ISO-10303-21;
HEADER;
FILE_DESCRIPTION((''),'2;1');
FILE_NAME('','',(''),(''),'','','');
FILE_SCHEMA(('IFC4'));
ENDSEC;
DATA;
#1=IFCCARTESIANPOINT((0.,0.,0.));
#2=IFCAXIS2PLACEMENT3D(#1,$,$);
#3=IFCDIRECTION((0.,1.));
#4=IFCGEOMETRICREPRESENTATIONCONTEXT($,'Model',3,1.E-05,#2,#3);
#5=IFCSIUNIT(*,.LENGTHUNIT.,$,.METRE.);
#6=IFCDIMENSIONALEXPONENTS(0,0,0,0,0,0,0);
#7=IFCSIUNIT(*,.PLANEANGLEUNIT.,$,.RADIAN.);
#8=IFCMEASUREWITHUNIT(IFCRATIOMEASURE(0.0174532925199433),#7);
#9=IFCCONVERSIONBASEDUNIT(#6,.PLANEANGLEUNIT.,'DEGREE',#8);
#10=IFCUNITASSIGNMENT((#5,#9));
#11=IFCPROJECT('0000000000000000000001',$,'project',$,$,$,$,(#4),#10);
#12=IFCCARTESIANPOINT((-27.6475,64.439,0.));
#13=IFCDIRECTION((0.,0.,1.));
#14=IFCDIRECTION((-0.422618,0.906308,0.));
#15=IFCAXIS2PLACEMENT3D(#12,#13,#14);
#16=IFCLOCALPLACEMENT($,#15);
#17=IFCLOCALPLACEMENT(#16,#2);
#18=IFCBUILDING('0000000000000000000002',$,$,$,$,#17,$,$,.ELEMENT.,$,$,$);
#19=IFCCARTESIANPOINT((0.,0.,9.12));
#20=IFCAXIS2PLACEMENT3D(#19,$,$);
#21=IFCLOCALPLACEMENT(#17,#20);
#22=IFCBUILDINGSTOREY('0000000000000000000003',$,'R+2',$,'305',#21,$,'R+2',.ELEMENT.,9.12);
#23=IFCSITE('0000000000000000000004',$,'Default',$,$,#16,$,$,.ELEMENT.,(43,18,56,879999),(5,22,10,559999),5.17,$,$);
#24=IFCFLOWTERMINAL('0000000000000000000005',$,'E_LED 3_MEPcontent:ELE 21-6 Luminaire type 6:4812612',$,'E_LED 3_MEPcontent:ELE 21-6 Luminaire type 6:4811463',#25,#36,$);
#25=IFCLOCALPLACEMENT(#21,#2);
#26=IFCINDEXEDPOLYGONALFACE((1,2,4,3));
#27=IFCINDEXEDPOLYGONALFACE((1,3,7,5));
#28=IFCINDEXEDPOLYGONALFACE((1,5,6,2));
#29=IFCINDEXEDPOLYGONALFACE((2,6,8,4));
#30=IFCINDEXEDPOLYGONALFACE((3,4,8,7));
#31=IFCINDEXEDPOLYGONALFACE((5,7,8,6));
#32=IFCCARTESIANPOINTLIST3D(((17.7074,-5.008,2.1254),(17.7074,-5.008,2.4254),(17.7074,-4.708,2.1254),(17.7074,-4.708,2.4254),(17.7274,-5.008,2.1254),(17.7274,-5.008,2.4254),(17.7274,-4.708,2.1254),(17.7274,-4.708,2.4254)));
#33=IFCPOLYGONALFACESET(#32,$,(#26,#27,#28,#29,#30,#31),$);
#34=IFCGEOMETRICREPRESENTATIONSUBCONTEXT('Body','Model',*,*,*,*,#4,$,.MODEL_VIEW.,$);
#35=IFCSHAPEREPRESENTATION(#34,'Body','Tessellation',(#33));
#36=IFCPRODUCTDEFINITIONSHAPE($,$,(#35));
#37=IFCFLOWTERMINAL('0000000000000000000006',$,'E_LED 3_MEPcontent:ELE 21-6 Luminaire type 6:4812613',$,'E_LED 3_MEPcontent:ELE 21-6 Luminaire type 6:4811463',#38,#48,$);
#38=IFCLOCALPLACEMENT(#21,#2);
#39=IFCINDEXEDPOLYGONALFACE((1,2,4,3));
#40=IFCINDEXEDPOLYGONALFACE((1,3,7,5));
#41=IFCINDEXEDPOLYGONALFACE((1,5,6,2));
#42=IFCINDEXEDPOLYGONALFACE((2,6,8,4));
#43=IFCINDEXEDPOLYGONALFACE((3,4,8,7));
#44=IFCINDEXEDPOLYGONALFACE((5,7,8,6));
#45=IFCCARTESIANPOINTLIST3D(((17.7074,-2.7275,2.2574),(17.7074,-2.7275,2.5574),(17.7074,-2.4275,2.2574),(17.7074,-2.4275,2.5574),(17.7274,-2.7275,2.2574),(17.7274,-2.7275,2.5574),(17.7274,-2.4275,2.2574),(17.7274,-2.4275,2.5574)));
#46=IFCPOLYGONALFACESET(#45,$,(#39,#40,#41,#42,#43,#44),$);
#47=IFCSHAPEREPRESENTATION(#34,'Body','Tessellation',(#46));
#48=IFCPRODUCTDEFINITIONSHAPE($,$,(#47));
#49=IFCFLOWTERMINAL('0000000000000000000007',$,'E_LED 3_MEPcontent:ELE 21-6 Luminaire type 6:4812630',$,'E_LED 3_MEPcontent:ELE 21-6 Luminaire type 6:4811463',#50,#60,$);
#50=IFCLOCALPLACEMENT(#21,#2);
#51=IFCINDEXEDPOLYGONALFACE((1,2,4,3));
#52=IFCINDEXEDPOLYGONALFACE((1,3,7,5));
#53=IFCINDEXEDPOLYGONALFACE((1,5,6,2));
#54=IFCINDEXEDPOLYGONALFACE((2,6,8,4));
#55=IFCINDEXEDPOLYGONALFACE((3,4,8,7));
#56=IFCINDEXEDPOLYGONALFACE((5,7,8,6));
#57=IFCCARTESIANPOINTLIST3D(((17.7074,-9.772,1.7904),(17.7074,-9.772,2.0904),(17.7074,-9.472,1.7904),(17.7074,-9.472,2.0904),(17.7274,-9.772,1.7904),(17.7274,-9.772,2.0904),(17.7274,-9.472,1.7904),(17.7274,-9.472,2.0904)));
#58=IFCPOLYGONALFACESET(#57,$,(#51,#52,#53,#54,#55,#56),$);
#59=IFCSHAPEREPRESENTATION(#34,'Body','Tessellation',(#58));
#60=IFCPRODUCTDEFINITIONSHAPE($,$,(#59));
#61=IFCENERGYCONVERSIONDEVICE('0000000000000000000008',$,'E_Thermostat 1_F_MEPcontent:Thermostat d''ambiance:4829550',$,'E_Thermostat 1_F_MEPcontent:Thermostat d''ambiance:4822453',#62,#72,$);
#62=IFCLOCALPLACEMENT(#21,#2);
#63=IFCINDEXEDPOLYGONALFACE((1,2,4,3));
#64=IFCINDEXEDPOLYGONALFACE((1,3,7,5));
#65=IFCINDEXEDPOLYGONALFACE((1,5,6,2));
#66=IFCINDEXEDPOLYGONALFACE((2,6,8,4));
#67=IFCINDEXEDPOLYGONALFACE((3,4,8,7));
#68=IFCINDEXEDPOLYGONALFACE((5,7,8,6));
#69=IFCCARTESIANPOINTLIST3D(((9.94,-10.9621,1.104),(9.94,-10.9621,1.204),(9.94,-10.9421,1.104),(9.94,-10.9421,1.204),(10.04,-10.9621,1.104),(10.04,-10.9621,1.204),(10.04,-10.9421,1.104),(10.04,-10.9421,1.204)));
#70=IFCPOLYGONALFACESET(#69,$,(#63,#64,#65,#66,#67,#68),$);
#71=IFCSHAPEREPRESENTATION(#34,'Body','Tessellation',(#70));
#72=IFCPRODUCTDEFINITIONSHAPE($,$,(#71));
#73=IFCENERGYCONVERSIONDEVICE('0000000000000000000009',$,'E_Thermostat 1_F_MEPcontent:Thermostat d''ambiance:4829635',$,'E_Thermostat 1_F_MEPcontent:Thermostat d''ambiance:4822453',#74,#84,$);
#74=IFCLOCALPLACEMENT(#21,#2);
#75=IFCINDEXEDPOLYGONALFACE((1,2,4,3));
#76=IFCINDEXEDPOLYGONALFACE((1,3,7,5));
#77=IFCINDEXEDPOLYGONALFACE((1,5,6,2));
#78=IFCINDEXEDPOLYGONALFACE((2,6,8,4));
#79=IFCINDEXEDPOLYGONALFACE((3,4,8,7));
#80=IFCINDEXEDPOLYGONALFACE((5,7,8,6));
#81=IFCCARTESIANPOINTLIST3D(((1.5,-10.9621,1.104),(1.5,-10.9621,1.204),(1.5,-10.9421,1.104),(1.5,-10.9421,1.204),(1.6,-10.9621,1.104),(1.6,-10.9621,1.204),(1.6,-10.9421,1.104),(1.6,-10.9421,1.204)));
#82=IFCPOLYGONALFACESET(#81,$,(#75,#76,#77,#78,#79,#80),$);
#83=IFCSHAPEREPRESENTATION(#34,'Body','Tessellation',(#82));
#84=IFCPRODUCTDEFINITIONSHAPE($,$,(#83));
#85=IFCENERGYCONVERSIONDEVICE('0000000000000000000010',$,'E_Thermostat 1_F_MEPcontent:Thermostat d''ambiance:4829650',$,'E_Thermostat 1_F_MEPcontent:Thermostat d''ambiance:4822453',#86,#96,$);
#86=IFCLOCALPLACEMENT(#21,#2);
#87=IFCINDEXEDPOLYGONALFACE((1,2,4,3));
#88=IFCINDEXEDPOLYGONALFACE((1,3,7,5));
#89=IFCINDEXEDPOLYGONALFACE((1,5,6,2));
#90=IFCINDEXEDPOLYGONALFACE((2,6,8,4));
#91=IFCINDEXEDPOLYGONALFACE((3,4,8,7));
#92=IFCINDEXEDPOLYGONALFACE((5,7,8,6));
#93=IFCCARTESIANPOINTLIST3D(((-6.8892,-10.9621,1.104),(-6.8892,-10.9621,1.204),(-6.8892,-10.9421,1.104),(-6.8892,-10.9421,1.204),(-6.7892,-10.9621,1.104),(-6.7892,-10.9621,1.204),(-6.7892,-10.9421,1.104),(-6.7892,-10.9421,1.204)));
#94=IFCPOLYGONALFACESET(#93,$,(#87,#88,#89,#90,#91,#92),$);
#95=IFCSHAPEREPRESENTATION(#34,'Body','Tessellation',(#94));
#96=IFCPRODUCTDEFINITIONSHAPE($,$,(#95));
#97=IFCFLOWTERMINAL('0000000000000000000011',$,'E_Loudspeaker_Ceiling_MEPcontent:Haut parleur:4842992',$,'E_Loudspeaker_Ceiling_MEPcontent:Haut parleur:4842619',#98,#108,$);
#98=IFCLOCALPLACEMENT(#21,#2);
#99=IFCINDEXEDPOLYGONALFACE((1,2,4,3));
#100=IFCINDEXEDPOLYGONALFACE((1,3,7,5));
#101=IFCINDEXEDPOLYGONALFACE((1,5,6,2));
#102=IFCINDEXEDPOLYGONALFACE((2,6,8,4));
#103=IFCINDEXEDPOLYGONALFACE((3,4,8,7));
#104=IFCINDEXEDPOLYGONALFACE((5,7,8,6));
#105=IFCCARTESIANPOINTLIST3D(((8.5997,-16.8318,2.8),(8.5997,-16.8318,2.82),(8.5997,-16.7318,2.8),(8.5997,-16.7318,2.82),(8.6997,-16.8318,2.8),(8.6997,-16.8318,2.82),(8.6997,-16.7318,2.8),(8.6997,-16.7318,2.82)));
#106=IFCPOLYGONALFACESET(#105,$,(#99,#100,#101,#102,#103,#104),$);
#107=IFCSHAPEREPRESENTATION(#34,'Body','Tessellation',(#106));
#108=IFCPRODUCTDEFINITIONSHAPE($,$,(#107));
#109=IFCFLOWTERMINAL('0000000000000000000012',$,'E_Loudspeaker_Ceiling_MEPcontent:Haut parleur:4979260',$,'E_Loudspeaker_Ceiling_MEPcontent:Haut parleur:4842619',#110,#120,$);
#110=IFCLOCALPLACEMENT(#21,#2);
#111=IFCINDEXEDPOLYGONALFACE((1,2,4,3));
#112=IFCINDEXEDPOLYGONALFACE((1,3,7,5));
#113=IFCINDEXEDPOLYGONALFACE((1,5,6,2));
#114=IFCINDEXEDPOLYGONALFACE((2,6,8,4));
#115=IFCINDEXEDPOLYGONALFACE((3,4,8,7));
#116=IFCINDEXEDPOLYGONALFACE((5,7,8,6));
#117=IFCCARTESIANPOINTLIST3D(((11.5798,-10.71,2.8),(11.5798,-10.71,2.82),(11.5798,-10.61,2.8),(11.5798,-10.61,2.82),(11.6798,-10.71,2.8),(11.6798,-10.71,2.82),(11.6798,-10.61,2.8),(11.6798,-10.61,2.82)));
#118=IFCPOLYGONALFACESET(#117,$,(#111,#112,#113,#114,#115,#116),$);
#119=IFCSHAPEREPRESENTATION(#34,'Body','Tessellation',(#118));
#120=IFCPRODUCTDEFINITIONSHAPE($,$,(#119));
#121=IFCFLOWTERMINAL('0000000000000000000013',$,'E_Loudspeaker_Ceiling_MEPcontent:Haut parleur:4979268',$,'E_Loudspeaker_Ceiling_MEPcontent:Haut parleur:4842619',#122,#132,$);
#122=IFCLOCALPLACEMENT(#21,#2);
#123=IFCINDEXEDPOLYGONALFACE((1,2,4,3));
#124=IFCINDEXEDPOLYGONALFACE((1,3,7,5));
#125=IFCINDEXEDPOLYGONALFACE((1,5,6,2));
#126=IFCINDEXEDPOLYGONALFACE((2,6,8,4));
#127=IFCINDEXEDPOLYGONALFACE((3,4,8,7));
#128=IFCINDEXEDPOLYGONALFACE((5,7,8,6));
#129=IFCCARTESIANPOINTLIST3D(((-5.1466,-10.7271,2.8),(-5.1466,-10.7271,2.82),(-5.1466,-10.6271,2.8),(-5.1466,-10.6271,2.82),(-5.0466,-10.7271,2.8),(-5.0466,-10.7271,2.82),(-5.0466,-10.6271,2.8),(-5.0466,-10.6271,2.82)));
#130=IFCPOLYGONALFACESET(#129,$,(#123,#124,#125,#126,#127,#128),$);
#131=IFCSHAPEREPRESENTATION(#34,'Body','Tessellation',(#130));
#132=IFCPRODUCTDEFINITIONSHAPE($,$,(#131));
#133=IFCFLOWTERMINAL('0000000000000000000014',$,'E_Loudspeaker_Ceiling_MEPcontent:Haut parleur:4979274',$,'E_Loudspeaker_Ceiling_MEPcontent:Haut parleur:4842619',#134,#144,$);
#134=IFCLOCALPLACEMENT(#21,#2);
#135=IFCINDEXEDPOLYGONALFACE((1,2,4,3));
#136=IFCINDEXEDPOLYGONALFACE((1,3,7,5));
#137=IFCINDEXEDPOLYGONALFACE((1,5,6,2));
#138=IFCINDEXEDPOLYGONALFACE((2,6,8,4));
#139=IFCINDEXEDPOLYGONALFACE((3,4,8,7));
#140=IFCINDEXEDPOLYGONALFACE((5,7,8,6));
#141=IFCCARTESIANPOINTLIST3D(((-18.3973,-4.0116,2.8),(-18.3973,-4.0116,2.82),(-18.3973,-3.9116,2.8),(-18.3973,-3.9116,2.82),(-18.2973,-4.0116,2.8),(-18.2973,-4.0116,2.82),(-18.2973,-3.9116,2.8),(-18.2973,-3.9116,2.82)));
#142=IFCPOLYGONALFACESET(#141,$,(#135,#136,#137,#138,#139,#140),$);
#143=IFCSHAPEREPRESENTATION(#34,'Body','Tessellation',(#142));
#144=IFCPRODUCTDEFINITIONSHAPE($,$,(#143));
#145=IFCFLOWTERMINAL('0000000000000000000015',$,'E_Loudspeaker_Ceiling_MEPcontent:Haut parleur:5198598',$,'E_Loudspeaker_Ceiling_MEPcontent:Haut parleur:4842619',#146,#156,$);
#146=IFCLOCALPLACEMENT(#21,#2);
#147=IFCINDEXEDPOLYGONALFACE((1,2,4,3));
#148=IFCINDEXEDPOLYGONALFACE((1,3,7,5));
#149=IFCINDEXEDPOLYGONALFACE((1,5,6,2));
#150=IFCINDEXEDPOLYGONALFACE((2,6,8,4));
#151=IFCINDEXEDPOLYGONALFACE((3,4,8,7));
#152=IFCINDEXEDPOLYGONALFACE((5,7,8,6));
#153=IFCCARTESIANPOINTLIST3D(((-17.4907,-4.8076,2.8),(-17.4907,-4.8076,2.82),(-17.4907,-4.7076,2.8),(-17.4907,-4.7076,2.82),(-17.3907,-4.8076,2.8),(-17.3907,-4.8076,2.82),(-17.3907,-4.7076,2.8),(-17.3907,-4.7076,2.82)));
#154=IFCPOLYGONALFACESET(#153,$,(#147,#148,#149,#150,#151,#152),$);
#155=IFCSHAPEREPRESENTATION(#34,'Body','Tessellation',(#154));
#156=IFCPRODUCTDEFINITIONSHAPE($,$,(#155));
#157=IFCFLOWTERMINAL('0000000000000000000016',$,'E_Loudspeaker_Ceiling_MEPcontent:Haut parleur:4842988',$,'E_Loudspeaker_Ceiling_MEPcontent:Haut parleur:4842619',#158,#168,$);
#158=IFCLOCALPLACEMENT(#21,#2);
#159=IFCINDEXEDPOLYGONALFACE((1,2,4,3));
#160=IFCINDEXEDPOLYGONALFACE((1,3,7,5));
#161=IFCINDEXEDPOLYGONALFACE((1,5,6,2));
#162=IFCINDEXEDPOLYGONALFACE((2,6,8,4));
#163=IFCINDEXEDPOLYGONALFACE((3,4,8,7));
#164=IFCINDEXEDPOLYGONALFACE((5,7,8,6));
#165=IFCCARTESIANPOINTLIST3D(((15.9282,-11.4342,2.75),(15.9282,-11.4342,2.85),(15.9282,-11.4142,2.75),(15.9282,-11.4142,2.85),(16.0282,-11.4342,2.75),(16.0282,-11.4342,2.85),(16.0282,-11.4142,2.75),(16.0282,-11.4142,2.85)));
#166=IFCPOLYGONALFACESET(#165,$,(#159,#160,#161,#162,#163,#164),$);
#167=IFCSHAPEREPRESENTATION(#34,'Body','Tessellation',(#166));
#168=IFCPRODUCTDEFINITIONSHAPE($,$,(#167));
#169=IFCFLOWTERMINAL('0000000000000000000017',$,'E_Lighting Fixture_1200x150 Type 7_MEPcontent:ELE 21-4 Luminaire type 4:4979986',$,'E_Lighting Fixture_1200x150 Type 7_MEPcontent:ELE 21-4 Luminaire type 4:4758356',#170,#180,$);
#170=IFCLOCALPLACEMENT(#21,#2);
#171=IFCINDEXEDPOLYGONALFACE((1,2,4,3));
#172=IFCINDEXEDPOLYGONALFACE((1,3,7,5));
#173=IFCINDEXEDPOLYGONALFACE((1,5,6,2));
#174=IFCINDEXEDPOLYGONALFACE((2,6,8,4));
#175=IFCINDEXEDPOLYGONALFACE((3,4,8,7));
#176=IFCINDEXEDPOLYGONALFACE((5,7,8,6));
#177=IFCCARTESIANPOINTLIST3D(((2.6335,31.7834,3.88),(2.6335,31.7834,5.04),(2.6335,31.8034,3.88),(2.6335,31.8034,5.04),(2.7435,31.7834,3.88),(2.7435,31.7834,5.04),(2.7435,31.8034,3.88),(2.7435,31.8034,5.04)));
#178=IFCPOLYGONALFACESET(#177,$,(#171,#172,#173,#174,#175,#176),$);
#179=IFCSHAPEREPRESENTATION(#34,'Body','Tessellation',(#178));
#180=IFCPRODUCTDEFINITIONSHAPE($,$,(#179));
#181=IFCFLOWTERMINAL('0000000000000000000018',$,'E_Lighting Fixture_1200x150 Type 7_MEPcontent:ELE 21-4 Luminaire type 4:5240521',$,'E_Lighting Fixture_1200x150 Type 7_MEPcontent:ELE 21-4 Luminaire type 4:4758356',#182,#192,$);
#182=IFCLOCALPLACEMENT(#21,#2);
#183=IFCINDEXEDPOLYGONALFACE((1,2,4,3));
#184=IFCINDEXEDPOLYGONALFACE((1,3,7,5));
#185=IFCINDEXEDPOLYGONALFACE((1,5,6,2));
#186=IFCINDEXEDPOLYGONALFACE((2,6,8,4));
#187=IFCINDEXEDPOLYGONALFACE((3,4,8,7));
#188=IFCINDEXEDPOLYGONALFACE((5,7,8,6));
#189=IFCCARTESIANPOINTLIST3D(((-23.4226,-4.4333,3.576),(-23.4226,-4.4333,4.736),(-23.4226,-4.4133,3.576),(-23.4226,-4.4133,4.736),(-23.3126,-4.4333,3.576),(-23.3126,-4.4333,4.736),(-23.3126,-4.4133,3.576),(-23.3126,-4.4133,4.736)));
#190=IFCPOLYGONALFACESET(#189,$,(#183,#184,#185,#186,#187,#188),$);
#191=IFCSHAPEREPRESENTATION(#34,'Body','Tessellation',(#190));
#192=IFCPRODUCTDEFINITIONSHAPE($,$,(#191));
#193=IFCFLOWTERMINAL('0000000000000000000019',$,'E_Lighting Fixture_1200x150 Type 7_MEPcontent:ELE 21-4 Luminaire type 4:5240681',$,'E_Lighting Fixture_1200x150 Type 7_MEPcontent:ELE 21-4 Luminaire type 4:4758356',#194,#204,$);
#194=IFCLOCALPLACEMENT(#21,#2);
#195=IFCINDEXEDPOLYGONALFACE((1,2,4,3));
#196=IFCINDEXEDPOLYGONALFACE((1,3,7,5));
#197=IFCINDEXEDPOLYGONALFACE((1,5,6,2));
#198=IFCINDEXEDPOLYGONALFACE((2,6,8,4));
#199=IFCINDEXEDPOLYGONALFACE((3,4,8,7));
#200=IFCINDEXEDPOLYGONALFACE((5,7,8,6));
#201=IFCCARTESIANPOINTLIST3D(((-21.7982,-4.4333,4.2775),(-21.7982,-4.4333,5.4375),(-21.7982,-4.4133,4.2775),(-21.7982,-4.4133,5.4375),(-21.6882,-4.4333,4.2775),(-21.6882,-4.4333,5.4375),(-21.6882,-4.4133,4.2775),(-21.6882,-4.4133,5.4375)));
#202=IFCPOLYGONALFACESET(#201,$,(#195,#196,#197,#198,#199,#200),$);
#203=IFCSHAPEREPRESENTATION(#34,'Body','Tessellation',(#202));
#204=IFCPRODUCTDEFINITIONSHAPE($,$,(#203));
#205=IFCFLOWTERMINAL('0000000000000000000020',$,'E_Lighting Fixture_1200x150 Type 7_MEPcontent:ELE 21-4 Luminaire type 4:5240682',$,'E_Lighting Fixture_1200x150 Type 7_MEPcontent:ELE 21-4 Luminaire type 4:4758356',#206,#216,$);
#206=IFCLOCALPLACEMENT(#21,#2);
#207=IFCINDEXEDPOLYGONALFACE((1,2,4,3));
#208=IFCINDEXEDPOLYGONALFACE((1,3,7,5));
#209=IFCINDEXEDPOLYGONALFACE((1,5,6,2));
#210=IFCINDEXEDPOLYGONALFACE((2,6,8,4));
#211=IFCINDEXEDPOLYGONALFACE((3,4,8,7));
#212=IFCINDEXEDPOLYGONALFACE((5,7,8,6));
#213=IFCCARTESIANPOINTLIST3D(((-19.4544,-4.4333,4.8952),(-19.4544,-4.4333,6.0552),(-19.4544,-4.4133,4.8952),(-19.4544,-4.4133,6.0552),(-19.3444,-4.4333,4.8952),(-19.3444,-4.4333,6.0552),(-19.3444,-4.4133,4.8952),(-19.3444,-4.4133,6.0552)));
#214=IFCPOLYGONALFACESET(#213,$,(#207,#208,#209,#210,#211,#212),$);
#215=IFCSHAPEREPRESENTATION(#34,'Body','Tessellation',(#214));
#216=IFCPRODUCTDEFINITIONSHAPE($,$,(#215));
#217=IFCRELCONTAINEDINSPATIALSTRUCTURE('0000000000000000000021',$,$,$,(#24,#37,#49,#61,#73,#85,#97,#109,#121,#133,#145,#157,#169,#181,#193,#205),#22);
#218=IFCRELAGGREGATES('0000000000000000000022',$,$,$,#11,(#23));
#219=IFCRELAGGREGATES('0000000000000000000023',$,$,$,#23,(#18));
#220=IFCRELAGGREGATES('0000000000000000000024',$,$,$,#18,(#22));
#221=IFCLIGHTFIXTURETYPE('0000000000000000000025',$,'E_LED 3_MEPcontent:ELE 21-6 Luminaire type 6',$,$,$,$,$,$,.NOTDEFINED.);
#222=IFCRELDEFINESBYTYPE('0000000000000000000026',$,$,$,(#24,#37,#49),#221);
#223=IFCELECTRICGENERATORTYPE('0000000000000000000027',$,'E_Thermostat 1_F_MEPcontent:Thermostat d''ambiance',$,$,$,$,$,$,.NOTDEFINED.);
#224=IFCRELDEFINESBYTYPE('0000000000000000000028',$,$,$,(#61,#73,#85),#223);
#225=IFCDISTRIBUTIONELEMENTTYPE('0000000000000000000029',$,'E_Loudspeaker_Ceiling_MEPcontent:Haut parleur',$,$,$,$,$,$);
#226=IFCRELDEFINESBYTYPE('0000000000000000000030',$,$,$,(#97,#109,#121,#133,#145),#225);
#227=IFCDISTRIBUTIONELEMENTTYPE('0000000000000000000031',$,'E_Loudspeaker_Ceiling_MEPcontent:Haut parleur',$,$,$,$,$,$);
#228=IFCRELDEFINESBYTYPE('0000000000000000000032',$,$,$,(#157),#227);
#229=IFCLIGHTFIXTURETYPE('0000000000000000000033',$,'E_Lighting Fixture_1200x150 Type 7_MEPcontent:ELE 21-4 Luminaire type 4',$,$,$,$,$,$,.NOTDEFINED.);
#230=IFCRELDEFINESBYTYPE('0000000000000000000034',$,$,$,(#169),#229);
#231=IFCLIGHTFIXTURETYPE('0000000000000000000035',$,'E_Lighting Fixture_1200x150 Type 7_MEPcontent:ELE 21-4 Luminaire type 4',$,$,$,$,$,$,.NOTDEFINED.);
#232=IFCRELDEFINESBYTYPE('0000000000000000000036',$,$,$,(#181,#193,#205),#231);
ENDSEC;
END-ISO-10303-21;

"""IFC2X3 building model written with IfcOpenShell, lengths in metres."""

from ifc_helpers import new_model, entity, si_unit, converted_unit, direction, frame, frame_2d, origin, origin_2d_with_axis, place, context, subcontext, project, spatial, rectangle, extrude, source, transform, mapped, type_object, type_shapes, element, save


model = new_model("IFC2X3")

# Units and contexts
model_context = context("Model", 3, precision=1e-05, world=origin(), true_north=direction((0.0, 1.0)))
body_context = subcontext(model_context, "Body", "Model", "MODEL_VIEW")
ifc_project = project(units=[si_unit("LENGTHUNIT", "METRE"), converted_unit("PLANEANGLEUNIT", "DEGREE", entity("IfcRatioMeasure", 0.0174532925199433), si_unit("PLANEANGLEUNIT", "RADIAN"), dimensions=[0, 0, 0, 0, 0, 0, 0])], contexts=[model_context])

# Site, building, storey
site_placement = place(None, frame((-27.6475, 64.439, 0.0), z_axis=(0.0, 0.0, 1.0), x_axis=(-0.422618, 0.906308, 0.0)))
site = spatial("IfcSite", under=ifc_project, at=site_placement, Name="Default", CompositionType="ELEMENT", RefLatitude=(43, 18, 56, 879999), RefLongitude=(5, 22, 10, 559999), RefElevation=5.17)
building_placement = place(site_placement, origin())
building = spatial("IfcBuilding", under=site, at=building_placement, CompositionType="ELEMENT")
storey_placement = place(building_placement, frame((0.0, 0.0, 9.12)))
storey = spatial("IfcBuildingStorey", under=building, at=storey_placement, Name="R+2", ObjectType="305", LongName="R+2", CompositionType="ELEMENT", Elevation=9.12)

# Flow terminals
light_fixture_type_1 = type_object("IfcLightFixtureType", Name="E_LED 3_MEPcontent:ELE 21-6 Luminaire type 6", PredefinedType="NOTDEFINED")
shared_shape_1 = source(origin(), body_context, "Body", "SweptSolid", [
    extrude(rectangle(XDim=0.02, YDim=0.3, at=origin_2d_with_axis()), frame((0.0, 0.01, -0.15), z_axis=(0.0, 0.0, 1.0), x_axis=(0.0, -1.0, 0.0)), (0.0, 0.0, 1.0), 0.3),
])
type_shapes(light_fixture_type_1, [shared_shape_1])
for number, where, z_axis, x_axis, name in (
    (1, (17.7074, -4.858, 2.2754), (0.0, 0.0, 1.0), (0.0, -1.0, 0.0), "E_LED 3_MEPcontent:ELE 21-6 Luminaire type 6:4812612"),
    (2, (17.7074, -2.5775, 2.4074), (0.0, 0.0, 1.0), (0.0, -1.0, 0.0), "E_LED 3_MEPcontent:ELE 21-6 Luminaire type 6:4812613"),
    (3, (17.7074, -9.622, 1.9404), (0.0, 0.0, 1.0), (0.0, -1.0, 0.0), "E_LED 3_MEPcontent:ELE 21-6 Luminaire type 6:4812630"),
):
    element("IfcFlowTerminal", number, at=place(storey_placement, frame(where, z_axis=z_axis, x_axis=x_axis)), inside=storey, type_object=light_fixture_type_1, Name=name, ObjectType="E_LED 3_MEPcontent:ELE 21-6 Luminaire type 6:4811463", context=body_context, shape_type="MappedRepresentation", body=[
        mapped(shared_shape_1, transform((0.0, 0.0, 0.0), scale=1.0)),
    ])

# Energy conversion devices
electric_generator_type = type_object("IfcElectricGeneratorType", Name="E_Thermostat 1_F_MEPcontent:Thermostat d'ambiance", PredefinedType="NOTDEFINED")
shared_shape_2 = source(origin(), body_context, "Body", "SweptSolid", [
    extrude(rectangle(XDim=0.1, YDim=0.1, at=origin_2d_with_axis()), frame((0.0, 0.0, 0.0), z_axis=(0.0, 0.0, 1.0), x_axis=(0.0, 1.0, 0.0)), (0.0, 0.0, 1.0), 0.02),
])
type_shapes(electric_generator_type, [shared_shape_2])
for number, where, z_axis, x_axis, name in (
    (4, (9.99, -10.9421, 1.154), (0.0, -1.0, 0.0), (1.0, 0.0, 0.0), "E_Thermostat 1_F_MEPcontent:Thermostat d'ambiance:4829550"),
    (5, (1.55, -10.9421, 1.154), (0.0, -1.0, 0.0), (1.0, 0.0, 0.0), "E_Thermostat 1_F_MEPcontent:Thermostat d'ambiance:4829635"),
    (6, (-6.8392, -10.9421, 1.154), (0.0, -1.0, 0.0), (1.0, 0.0, 0.0), "E_Thermostat 1_F_MEPcontent:Thermostat d'ambiance:4829650"),
):
    element("IfcEnergyConversionDevice", number, at=place(storey_placement, frame(where, z_axis=z_axis, x_axis=x_axis)), inside=storey, type_object=electric_generator_type, Name=name, ObjectType="E_Thermostat 1_F_MEPcontent:Thermostat d'ambiance:4822453", context=body_context, shape_type="MappedRepresentation", body=[
        mapped(shared_shape_2, transform((0.0, 0.0, 0.0), scale=1.0)),
    ])

# Flow terminals
distribution_element_type_1 = type_object("IfcDistributionElementType", Name="E_Loudspeaker_Ceiling_MEPcontent:Haut parleur")
shared_shape_3 = source(origin(), body_context, "Body", "SweptSolid", [
    extrude(rectangle(XDim=0.1, YDim=0.1, at=origin_2d_with_axis()), frame((0.0, 0.0, 0.0), z_axis=(0.0, 0.0, 1.0), x_axis=(0.0, -1.0, 0.0)), (0.0, 0.0, 1.0), 0.02),
])
type_shapes(distribution_element_type_1, [shared_shape_3])
flow_terminal_1_placement = place(storey_placement, frame((8.6497, -16.7818, 2.8), z_axis=(0.0, 0.0, 1.0), x_axis=(0.0, 1.0, 0.0)))
element("IfcFlowTerminal", 7, at=flow_terminal_1_placement, inside=storey, type_object=distribution_element_type_1, Name="E_Loudspeaker_Ceiling_MEPcontent:Haut parleur:4842992", ObjectType="E_Loudspeaker_Ceiling_MEPcontent:Haut parleur:4842619", context=body_context, shape_type="MappedRepresentation", body=[
    mapped(shared_shape_3, transform((0.0, 0.0, 0.0), scale=1.0)),
])
for number, where, name in (
    (8, (11.6298, -10.66, 2.8), "E_Loudspeaker_Ceiling_MEPcontent:Haut parleur:4979260"),
    (9, (-5.0966, -10.6771, 2.8), "E_Loudspeaker_Ceiling_MEPcontent:Haut parleur:4979268"),
    (10, (-18.3473, -3.9616, 2.8), "E_Loudspeaker_Ceiling_MEPcontent:Haut parleur:4979274"),
):
    element("IfcFlowTerminal", number, at=place(storey_placement, frame(where)), inside=storey, type_object=distribution_element_type_1, Name=name, ObjectType="E_Loudspeaker_Ceiling_MEPcontent:Haut parleur:4842619", context=body_context, shape_type="MappedRepresentation", body=[
        mapped(shared_shape_3, transform((0.0, 0.0, 0.0), scale=1.0)),
    ])
flow_terminal_2_placement = place(storey_placement, frame((-17.4407, -4.7576, 2.8), z_axis=(0.0, 0.0, 1.0), x_axis=(0.0, -1.0, 0.0)))
element("IfcFlowTerminal", 11, at=flow_terminal_2_placement, inside=storey, type_object=distribution_element_type_1, Name="E_Loudspeaker_Ceiling_MEPcontent:Haut parleur:5198598", ObjectType="E_Loudspeaker_Ceiling_MEPcontent:Haut parleur:4842619", context=body_context, shape_type="MappedRepresentation", body=[
    mapped(shared_shape_3, transform((0.0, 0.0, 0.0), scale=1.0)),
])
distribution_element_type_2 = type_object("IfcDistributionElementType", Name="E_Loudspeaker_Ceiling_MEPcontent:Haut parleur")
shared_shape_4 = source(origin(), body_context, "Body", "SweptSolid", [
    extrude(rectangle(XDim=0.02, YDim=0.1, at=frame_2d((0.0, 0.0), x_axis=(1.0, 0.0))), frame((0.0, 0.01, -0.05), z_axis=(0.0, 0.0, 1.0), x_axis=(0.0, -1.0, 0.0)), (0.0, 0.0, 1.0), 0.1),
])
type_shapes(distribution_element_type_2, [shared_shape_4])
flow_terminal_3_placement = place(storey_placement, frame((15.9782, -11.4142, 2.8), z_axis=(0.0, 0.0, 1.0), x_axis=(-1.0, 0.0, 0.0)))
element("IfcFlowTerminal", 12, at=flow_terminal_3_placement, inside=storey, type_object=distribution_element_type_2, Name="E_Loudspeaker_Ceiling_MEPcontent:Haut parleur:4842988", ObjectType="E_Loudspeaker_Ceiling_MEPcontent:Haut parleur:4842619", context=body_context, shape_type="MappedRepresentation", body=[
    mapped(shared_shape_4, transform((0.0, 0.0, 0.0), scale=1.0)),
])
light_fixture_type_2 = type_object("IfcLightFixtureType", Name="E_Lighting Fixture_1200x150 Type 7_MEPcontent:ELE 21-4 Luminaire type 4", PredefinedType="NOTDEFINED")
shared_shape_5 = source(origin(), body_context, "Body", "SweptSolid", [
    extrude(rectangle(XDim=0.02, YDim=0.11, at=frame_2d((0.0, 0.0), x_axis=(1.0, 0.0))), frame((0.01, 0.0, -0.58), z_axis=(0.0, 0.0, 1.0), x_axis=(-1.0, 0.0, 0.0)), (0.0, 0.0, 1.0), 1.16),
])
type_shapes(light_fixture_type_2, [shared_shape_5])
flow_terminal_4_placement = place(storey_placement, frame((2.6885, 31.8034, 4.46), z_axis=(0.0, 0.0, 1.0), x_axis=(0.0, -1.0, 0.0)))
element("IfcFlowTerminal", 13, at=flow_terminal_4_placement, inside=storey, type_object=light_fixture_type_2, Name="E_Lighting Fixture_1200x150 Type 7_MEPcontent:ELE 21-4 Luminaire type 4:4979986", ObjectType="E_Lighting Fixture_1200x150 Type 7_MEPcontent:ELE 21-4 Luminaire type 4:4758356", context=body_context, shape_type="MappedRepresentation", body=[
    mapped(shared_shape_5, transform((0.0, 0.0, 0.0), scale=1.0)),
])
light_fixture_type_3 = type_object("IfcLightFixtureType", Name="E_Lighting Fixture_1200x150 Type 7_MEPcontent:ELE 21-4 Luminaire type 4", PredefinedType="NOTDEFINED")
shared_shape_6 = source(origin(), body_context, "Body", "SweptSolid", [
    extrude(rectangle(XDim=0.02, YDim=0.11, at=frame_2d((0.0, 0.0), x_axis=(1.0, 0.0))), frame((0.0, 0.01, -0.58), z_axis=(0.0, 0.0, 1.0), x_axis=(0.0, -1.0, 0.0)), (0.0, 0.0, 1.0), 1.16),
])
type_shapes(light_fixture_type_3, [shared_shape_6])
for number, where, name in (
    (14, (-23.3676, -4.4333, 4.156), "E_Lighting Fixture_1200x150 Type 7_MEPcontent:ELE 21-4 Luminaire type 4:5240521"),
    (15, (-21.7432, -4.4333, 4.8575), "E_Lighting Fixture_1200x150 Type 7_MEPcontent:ELE 21-4 Luminaire type 4:5240681"),
    (16, (-19.3994, -4.4333, 5.4752), "E_Lighting Fixture_1200x150 Type 7_MEPcontent:ELE 21-4 Luminaire type 4:5240682"),
):
    element("IfcFlowTerminal", number, at=place(storey_placement, frame(where)), inside=storey, type_object=light_fixture_type_3, Name=name, ObjectType="E_Lighting Fixture_1200x150 Type 7_MEPcontent:ELE 21-4 Luminaire type 4:4758356", context=body_context, shape_type="MappedRepresentation", body=[
        mapped(shared_shape_6, transform((0.0, 0.0, 0.0), scale=1.0)),
    ])

save(model, "model.ifc")
